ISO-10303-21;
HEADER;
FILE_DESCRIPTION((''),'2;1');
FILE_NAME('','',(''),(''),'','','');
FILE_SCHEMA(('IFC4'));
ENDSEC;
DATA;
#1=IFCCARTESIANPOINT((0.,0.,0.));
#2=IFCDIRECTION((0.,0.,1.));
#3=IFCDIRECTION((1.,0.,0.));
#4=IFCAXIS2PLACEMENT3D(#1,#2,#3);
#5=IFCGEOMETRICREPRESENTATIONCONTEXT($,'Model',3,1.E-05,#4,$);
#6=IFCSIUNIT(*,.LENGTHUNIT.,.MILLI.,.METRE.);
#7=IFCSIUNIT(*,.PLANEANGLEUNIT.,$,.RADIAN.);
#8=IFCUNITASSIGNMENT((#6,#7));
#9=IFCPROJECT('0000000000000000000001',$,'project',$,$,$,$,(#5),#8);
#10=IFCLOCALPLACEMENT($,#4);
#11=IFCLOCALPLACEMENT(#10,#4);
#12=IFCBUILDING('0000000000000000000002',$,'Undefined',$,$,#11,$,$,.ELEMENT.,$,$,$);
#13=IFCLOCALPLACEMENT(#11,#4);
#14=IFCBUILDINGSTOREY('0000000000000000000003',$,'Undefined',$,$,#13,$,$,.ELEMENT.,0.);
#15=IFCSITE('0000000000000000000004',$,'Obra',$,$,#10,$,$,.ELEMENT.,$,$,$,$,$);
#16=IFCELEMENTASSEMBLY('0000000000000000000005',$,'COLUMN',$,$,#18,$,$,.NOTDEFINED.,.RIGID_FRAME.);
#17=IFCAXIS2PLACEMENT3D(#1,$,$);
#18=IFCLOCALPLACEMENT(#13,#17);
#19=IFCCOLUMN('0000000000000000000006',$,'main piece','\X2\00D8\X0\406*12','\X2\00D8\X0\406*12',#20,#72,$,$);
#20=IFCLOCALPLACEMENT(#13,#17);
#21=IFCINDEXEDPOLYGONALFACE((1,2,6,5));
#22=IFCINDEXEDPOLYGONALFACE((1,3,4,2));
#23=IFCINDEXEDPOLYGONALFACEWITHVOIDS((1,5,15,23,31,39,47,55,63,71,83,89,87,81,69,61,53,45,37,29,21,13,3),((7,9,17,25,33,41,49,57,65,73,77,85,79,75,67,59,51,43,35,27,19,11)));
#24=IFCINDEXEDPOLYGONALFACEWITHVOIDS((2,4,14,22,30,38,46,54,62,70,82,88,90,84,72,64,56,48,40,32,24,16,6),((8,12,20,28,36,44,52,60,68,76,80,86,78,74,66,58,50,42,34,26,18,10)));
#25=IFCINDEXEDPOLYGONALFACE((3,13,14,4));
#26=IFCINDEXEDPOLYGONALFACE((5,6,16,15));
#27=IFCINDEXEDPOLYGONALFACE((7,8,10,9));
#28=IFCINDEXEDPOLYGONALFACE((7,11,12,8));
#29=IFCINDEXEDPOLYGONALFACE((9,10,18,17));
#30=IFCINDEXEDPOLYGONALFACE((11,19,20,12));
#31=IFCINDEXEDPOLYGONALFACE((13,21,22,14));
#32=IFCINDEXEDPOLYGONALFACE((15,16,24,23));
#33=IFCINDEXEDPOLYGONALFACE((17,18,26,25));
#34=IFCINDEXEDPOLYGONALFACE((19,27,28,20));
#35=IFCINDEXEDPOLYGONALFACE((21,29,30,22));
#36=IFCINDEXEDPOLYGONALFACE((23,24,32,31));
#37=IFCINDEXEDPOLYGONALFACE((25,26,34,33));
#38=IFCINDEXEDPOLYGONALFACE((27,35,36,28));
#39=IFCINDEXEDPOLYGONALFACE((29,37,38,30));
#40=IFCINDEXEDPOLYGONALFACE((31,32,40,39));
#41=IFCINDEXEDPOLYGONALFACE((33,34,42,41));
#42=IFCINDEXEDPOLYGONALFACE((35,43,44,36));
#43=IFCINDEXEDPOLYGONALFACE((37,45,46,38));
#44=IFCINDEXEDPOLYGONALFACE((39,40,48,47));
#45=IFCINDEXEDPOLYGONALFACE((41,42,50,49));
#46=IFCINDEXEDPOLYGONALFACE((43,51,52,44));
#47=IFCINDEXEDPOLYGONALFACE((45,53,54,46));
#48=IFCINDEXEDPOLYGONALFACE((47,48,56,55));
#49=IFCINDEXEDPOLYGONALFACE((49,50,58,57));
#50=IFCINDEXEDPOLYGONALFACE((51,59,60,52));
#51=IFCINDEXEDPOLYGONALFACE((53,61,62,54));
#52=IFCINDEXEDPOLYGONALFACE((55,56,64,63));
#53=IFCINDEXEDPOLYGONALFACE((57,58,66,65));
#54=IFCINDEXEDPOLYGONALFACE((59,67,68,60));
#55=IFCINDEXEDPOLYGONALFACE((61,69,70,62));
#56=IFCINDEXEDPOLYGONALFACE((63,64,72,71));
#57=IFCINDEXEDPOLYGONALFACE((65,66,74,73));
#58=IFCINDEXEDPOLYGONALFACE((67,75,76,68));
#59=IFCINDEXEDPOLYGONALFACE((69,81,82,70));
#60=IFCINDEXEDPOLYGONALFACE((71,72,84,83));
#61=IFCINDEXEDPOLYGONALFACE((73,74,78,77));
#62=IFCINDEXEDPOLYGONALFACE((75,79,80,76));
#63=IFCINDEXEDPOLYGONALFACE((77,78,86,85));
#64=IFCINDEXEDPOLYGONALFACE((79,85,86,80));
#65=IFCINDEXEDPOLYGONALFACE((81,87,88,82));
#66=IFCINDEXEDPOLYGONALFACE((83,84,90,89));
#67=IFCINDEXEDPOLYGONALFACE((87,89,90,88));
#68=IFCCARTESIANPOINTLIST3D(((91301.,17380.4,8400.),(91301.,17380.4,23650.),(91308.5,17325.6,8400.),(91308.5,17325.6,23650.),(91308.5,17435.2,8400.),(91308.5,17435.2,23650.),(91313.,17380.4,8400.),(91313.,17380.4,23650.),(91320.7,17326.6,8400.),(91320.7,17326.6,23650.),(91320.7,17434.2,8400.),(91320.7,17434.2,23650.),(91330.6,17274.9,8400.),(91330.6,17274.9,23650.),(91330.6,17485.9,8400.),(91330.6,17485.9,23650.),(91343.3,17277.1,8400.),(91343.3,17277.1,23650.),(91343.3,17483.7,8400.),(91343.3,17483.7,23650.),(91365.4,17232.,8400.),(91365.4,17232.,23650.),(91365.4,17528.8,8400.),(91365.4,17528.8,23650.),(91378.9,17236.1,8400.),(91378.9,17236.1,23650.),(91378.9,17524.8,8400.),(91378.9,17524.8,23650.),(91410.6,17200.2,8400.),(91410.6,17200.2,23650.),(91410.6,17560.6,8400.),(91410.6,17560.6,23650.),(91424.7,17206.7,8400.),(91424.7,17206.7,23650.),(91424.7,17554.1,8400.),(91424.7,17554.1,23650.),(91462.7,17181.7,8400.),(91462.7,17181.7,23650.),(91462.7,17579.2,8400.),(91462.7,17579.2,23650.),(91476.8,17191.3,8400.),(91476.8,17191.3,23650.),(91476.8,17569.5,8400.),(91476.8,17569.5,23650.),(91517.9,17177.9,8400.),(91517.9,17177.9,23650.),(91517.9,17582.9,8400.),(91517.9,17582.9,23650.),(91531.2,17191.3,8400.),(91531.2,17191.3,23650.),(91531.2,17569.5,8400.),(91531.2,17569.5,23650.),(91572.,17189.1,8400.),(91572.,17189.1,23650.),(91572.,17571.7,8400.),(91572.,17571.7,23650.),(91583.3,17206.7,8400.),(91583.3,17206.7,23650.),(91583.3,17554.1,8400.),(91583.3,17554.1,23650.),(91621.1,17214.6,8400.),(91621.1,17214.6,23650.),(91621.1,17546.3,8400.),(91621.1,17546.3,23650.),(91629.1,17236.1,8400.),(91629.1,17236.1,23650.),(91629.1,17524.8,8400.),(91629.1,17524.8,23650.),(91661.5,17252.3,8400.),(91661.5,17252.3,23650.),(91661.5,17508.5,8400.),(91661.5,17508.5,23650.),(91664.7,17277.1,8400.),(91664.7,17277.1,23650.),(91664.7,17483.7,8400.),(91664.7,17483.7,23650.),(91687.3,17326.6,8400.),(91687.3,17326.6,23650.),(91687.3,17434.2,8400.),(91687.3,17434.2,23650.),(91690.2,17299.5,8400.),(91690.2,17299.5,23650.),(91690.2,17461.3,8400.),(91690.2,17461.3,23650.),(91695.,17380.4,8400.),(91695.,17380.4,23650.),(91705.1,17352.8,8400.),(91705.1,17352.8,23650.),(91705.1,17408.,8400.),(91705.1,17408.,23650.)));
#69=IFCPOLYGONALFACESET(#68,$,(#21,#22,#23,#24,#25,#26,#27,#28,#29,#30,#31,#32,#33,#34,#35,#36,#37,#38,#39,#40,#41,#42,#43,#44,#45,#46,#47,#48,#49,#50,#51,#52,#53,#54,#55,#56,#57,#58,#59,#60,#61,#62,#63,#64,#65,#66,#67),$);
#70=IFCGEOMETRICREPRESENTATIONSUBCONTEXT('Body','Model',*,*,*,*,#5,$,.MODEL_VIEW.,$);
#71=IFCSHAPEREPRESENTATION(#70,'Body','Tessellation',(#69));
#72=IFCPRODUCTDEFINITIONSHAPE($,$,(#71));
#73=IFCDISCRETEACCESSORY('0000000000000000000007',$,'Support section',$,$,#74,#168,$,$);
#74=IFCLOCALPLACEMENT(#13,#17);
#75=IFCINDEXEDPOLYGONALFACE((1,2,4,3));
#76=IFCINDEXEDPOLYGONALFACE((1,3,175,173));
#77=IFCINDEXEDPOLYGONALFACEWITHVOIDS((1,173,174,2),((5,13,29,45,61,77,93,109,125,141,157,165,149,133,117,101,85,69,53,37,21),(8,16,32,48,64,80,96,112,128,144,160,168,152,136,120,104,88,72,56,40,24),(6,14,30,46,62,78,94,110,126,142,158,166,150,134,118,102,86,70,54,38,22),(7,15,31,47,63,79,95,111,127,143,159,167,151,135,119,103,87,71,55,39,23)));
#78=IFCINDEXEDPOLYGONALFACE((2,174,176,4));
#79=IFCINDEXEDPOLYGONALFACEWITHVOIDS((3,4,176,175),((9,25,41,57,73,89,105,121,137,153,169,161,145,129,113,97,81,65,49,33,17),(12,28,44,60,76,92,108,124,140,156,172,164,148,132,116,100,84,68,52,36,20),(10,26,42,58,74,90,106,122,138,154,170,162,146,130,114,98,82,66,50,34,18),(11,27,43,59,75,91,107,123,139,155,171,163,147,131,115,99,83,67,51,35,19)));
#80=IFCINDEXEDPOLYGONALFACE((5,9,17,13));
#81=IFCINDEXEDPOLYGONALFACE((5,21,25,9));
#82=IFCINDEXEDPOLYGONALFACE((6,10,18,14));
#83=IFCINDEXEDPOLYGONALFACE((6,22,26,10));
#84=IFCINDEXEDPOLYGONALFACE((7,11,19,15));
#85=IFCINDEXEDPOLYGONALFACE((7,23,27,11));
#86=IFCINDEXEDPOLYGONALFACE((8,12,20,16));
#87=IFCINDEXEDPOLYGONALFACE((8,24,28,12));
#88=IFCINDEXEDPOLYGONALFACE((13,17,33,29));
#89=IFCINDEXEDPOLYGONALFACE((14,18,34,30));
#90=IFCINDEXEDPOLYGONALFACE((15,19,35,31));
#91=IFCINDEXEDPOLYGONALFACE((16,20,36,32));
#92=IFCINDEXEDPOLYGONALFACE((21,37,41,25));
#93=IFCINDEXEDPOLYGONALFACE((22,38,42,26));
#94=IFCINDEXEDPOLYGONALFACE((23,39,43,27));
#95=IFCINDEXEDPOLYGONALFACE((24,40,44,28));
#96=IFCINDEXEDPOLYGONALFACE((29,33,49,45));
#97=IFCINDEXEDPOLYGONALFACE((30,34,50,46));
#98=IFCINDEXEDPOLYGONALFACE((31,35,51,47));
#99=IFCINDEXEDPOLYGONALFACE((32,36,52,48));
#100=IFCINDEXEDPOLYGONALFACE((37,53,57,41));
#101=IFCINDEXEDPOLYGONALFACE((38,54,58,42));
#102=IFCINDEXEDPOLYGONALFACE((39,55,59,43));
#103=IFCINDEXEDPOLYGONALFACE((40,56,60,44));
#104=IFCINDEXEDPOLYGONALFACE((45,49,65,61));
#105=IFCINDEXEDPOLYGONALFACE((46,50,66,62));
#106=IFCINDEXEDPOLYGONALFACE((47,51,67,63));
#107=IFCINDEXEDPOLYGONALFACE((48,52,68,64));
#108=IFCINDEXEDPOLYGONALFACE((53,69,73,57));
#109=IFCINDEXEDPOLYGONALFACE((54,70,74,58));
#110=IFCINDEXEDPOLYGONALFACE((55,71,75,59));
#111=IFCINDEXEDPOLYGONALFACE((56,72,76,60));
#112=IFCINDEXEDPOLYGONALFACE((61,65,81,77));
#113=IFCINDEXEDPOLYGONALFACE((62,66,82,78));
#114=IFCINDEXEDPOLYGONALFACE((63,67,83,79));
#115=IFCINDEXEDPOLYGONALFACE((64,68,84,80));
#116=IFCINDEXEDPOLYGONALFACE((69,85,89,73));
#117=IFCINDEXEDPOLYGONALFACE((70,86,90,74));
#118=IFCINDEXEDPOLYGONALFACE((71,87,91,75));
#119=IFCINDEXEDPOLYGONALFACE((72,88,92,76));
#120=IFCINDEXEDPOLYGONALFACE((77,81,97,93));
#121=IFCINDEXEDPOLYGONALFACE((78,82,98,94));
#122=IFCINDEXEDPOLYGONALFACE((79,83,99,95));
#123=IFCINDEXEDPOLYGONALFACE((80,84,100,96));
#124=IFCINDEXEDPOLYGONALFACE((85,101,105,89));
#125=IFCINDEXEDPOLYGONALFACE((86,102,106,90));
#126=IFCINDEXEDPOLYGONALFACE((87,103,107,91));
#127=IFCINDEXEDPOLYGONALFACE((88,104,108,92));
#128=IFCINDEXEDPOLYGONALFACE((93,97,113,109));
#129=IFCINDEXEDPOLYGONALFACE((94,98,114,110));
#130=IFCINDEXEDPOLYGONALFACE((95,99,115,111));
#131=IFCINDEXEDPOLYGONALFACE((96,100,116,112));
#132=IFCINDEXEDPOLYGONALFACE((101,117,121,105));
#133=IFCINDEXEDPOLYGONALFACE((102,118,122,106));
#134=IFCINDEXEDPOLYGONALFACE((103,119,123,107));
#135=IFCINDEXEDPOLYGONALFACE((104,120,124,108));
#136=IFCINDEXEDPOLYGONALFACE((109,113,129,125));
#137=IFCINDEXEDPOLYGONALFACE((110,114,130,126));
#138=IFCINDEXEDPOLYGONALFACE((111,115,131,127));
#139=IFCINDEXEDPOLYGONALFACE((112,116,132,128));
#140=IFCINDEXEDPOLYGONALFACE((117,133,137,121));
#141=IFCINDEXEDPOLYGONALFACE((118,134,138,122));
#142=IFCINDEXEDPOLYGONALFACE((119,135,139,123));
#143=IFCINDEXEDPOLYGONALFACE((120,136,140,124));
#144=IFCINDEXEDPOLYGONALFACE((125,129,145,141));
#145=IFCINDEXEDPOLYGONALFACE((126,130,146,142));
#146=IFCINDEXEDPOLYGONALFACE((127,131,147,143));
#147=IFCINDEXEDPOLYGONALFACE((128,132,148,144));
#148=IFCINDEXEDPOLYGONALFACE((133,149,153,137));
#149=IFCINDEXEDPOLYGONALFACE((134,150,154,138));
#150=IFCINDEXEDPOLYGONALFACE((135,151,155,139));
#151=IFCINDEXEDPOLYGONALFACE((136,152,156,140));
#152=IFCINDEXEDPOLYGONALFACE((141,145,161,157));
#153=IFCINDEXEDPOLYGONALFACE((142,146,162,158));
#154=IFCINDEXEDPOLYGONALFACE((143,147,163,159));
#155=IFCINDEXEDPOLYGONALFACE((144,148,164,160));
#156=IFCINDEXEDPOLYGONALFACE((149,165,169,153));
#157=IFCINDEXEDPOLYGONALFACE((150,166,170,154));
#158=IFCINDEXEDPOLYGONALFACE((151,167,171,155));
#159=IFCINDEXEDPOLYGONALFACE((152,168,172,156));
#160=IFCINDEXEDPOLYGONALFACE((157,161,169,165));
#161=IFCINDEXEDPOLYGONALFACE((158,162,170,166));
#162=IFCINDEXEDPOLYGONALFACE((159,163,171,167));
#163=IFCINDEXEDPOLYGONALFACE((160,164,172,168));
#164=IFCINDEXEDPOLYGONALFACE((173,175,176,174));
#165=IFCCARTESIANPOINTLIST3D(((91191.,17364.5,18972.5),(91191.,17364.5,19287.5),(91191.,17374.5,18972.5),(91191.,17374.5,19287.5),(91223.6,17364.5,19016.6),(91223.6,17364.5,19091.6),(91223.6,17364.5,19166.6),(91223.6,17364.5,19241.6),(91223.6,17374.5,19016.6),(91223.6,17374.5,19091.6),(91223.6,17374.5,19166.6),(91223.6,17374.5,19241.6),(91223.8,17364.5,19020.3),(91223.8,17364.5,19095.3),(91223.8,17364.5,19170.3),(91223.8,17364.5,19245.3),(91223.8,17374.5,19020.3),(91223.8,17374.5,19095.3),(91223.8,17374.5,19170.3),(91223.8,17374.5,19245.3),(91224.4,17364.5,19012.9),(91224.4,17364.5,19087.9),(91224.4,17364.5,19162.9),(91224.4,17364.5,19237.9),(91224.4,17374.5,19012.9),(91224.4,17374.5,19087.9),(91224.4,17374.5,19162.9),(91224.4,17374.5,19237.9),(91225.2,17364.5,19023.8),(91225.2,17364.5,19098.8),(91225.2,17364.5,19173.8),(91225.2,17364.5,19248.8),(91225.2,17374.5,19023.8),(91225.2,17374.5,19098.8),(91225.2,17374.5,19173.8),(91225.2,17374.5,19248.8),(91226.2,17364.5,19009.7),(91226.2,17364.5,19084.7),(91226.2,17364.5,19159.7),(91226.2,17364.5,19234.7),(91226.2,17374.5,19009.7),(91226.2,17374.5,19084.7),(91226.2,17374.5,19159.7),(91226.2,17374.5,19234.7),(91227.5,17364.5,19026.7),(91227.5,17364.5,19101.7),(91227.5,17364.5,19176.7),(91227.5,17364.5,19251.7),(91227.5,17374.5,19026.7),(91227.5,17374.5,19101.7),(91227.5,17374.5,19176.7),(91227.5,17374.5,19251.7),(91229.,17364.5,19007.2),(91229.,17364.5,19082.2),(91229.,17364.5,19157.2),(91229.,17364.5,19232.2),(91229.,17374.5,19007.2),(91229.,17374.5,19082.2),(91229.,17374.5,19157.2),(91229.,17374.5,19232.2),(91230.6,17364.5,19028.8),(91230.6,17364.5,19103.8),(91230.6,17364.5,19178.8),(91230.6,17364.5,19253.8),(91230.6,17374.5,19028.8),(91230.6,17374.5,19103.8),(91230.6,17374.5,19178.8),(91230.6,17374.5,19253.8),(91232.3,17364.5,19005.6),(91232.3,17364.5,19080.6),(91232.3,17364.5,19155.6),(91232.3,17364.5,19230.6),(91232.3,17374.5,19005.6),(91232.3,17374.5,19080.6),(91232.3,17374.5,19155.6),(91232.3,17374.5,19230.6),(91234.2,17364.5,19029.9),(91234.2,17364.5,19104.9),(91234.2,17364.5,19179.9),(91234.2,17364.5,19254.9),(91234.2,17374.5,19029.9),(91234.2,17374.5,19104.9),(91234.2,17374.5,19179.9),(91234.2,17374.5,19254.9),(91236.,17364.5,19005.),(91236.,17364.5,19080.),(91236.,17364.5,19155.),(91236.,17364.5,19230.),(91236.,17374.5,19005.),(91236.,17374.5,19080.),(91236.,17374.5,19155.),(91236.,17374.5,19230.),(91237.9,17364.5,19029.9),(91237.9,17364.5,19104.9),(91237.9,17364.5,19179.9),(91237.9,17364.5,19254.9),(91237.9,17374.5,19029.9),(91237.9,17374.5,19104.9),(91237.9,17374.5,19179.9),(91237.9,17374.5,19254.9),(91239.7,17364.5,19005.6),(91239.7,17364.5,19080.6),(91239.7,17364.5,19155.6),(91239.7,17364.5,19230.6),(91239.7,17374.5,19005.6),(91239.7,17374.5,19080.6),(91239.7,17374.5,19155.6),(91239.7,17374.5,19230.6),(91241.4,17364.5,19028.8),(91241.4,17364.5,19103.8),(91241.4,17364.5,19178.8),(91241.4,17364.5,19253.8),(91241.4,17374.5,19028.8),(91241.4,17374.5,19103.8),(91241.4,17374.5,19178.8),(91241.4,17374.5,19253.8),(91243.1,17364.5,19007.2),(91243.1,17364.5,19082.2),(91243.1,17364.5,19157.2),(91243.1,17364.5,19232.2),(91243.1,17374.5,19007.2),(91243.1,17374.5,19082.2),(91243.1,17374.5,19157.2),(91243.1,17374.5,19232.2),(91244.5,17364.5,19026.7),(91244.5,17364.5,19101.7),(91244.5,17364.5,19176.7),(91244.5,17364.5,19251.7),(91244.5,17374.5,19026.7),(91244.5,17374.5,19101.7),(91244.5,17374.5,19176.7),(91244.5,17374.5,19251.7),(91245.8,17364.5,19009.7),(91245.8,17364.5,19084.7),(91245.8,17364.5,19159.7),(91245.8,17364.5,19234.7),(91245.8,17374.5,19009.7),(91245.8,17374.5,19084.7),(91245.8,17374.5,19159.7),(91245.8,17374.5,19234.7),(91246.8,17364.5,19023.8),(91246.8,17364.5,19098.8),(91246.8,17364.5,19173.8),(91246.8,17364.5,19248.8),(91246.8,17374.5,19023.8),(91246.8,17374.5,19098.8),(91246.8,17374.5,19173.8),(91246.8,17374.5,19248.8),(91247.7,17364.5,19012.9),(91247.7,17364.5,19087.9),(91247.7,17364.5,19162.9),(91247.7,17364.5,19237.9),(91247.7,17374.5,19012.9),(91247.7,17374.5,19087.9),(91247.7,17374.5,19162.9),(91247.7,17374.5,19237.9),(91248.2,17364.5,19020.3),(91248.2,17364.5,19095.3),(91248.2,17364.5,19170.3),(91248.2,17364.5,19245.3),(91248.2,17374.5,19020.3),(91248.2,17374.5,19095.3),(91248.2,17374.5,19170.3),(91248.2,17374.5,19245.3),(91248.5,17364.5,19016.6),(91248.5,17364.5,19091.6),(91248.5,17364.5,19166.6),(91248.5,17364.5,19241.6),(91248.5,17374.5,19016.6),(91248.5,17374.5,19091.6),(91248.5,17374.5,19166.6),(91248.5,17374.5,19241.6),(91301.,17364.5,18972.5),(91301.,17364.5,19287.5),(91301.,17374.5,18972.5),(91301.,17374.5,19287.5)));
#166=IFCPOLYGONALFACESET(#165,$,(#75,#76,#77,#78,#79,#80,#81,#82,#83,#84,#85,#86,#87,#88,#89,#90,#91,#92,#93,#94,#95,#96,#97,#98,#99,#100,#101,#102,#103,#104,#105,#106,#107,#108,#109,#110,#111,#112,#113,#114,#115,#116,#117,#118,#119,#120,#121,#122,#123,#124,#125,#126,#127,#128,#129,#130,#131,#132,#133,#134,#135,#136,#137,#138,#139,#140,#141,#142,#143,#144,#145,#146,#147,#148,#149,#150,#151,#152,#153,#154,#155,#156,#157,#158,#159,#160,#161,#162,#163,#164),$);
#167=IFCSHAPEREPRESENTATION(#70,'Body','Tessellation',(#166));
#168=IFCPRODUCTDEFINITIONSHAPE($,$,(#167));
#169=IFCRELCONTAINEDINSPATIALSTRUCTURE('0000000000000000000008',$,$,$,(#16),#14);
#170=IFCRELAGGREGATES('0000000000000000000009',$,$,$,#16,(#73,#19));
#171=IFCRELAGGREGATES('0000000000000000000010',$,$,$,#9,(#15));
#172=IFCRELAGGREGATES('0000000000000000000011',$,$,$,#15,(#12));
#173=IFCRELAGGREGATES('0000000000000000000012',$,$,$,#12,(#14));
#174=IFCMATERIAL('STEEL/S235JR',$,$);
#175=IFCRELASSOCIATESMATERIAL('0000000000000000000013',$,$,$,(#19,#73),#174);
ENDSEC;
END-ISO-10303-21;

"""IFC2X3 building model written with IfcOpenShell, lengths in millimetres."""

from ifc_helpers import new_model, si_unit, frame, origin_with_axes, origin_2d_with_axis, place, context, subcontext, project, spatial, rectangle, circle, hollow_circle, extrude, clip, halfspace, source, transform, mapped, material, element, aggregate, save


model = new_model("IFC2X3")

# Units and contexts
model_context = context("Model", 3, precision=1e-05, world=origin_with_axes())
body_context = subcontext(model_context, "Body", "Model", "MODEL_VIEW")
ifc_project = project(units=[si_unit("LENGTHUNIT", "METRE", prefix="MILLI"), si_unit("PLANEANGLEUNIT", "RADIAN")], contexts=[model_context])

# Site, building, storey
site_placement = place(None, origin_with_axes())
site = spatial("IfcSite", under=ifc_project, at=site_placement, Name="Obra", CompositionType="ELEMENT")
building_placement = place(site_placement, origin_with_axes())
building = spatial("IfcBuilding", under=site, at=building_placement, Name="Undefined", CompositionType="ELEMENT")
storey_placement = place(building_placement, origin_with_axes())
storey = spatial("IfcBuildingStorey", under=building, at=storey_placement, Name="Undefined", CompositionType="ELEMENT", Elevation=0.0)

# Element assembly, column
assembly_1_placement = place(storey_placement, origin_with_axes())
assembly_1 = element("IfcElementAssembly", 1, at=assembly_1_placement, inside=storey, Name="COLUMN", AssemblyPlace="NOTDEFINED", PredefinedType="RIGID_FRAME")
ifc_material_1 = material(Name="STEEL/S235JR")
column_placement = place(assembly_1_placement, frame((91504.0, 17380.4, 8384.0), z_axis=(0.0, 0.0, 1.0), x_axis=(0.0, 1.0, 0.0)))
column = element("IfcColumn", 2, at=column_placement, material=ifc_material_1, Name="main piece", Description="Ø406*12", ObjectType="Ø406*12", context=body_context, shape_type="Clipping", body=[
    clip(extrude(hollow_circle(Radius=203.0, WallThickness=12.0, at=origin_2d_with_axis()), frame((0.0, 0.0, 15266.0), z_axis=(0.0, 0.0, -1.0), x_axis=(0.0, 1.0, 0.0)), (0.0, 0.0, 1.0), 15250.0), halfspace(frame((-203.0, 0.0, 16.0), z_axis=(0.0, 0.0, 1.0), x_axis=(0.0, 1.0, 0.0)), True)),
])

# Discrete accessory, opening
discrete_accessory_1_placement = place(assembly_1_placement, frame((91246.0, 17369.5, 18972.5), z_axis=(0.0, 0.0, 1.0), x_axis=(1.0, 0.0, 0.0)))
discrete_accessory_1 = element("IfcDiscreteAccessory", 3, at=discrete_accessory_1_placement, material=ifc_material_1, Name="Support section", context=body_context, shape_type="SweptSolid", body=[
    extrude(rectangle(XDim=10.0, YDim=110.0, at=origin_2d_with_axis()), frame((0.0, 0.0, 315.0), z_axis=(0.0, 0.0, -1.0), x_axis=(0.0, 1.0, 0.0)), (0.0, 0.0, 1.0), 315.0),
])
shared_shape_1 = source(origin_with_axes(), body_context, "Body", "SweptSolid", [
    extrude(circle(Radius=12.5, at=origin_2d_with_axis()), frame((0.0, 5.7, 0.0), z_axis=(0.0, 1.0, 0.0), x_axis=(1.0, 0.0, 0.0)), (0.0, 0.0, 1.0), 10.2),
])
opening_1_placement = place(assembly_1_placement, frame((91281.0, 17380.2, 19350.0), z_axis=(-1.0, 0.0, 0.0), x_axis=(0.0, 0.0, -1.0)))
element("IfcOpeningElement", 4, at=opening_1_placement, cuts=discrete_accessory_1, ObjectType="Opening", context=body_context, shape_type="MappedRepresentation", body=[
    mapped(shared_shape_1, transform((107.5, 0.0, 45.0))),
    mapped(shared_shape_1, transform((182.5, 0.0, 45.0))),
    mapped(shared_shape_1, transform((257.5, 0.0, 45.0))),
    mapped(shared_shape_1, transform((332.5, 0.0, 45.0))),
])

aggregate(assembly_1, [discrete_accessory_1, column])

save(model, "model.ifc")
